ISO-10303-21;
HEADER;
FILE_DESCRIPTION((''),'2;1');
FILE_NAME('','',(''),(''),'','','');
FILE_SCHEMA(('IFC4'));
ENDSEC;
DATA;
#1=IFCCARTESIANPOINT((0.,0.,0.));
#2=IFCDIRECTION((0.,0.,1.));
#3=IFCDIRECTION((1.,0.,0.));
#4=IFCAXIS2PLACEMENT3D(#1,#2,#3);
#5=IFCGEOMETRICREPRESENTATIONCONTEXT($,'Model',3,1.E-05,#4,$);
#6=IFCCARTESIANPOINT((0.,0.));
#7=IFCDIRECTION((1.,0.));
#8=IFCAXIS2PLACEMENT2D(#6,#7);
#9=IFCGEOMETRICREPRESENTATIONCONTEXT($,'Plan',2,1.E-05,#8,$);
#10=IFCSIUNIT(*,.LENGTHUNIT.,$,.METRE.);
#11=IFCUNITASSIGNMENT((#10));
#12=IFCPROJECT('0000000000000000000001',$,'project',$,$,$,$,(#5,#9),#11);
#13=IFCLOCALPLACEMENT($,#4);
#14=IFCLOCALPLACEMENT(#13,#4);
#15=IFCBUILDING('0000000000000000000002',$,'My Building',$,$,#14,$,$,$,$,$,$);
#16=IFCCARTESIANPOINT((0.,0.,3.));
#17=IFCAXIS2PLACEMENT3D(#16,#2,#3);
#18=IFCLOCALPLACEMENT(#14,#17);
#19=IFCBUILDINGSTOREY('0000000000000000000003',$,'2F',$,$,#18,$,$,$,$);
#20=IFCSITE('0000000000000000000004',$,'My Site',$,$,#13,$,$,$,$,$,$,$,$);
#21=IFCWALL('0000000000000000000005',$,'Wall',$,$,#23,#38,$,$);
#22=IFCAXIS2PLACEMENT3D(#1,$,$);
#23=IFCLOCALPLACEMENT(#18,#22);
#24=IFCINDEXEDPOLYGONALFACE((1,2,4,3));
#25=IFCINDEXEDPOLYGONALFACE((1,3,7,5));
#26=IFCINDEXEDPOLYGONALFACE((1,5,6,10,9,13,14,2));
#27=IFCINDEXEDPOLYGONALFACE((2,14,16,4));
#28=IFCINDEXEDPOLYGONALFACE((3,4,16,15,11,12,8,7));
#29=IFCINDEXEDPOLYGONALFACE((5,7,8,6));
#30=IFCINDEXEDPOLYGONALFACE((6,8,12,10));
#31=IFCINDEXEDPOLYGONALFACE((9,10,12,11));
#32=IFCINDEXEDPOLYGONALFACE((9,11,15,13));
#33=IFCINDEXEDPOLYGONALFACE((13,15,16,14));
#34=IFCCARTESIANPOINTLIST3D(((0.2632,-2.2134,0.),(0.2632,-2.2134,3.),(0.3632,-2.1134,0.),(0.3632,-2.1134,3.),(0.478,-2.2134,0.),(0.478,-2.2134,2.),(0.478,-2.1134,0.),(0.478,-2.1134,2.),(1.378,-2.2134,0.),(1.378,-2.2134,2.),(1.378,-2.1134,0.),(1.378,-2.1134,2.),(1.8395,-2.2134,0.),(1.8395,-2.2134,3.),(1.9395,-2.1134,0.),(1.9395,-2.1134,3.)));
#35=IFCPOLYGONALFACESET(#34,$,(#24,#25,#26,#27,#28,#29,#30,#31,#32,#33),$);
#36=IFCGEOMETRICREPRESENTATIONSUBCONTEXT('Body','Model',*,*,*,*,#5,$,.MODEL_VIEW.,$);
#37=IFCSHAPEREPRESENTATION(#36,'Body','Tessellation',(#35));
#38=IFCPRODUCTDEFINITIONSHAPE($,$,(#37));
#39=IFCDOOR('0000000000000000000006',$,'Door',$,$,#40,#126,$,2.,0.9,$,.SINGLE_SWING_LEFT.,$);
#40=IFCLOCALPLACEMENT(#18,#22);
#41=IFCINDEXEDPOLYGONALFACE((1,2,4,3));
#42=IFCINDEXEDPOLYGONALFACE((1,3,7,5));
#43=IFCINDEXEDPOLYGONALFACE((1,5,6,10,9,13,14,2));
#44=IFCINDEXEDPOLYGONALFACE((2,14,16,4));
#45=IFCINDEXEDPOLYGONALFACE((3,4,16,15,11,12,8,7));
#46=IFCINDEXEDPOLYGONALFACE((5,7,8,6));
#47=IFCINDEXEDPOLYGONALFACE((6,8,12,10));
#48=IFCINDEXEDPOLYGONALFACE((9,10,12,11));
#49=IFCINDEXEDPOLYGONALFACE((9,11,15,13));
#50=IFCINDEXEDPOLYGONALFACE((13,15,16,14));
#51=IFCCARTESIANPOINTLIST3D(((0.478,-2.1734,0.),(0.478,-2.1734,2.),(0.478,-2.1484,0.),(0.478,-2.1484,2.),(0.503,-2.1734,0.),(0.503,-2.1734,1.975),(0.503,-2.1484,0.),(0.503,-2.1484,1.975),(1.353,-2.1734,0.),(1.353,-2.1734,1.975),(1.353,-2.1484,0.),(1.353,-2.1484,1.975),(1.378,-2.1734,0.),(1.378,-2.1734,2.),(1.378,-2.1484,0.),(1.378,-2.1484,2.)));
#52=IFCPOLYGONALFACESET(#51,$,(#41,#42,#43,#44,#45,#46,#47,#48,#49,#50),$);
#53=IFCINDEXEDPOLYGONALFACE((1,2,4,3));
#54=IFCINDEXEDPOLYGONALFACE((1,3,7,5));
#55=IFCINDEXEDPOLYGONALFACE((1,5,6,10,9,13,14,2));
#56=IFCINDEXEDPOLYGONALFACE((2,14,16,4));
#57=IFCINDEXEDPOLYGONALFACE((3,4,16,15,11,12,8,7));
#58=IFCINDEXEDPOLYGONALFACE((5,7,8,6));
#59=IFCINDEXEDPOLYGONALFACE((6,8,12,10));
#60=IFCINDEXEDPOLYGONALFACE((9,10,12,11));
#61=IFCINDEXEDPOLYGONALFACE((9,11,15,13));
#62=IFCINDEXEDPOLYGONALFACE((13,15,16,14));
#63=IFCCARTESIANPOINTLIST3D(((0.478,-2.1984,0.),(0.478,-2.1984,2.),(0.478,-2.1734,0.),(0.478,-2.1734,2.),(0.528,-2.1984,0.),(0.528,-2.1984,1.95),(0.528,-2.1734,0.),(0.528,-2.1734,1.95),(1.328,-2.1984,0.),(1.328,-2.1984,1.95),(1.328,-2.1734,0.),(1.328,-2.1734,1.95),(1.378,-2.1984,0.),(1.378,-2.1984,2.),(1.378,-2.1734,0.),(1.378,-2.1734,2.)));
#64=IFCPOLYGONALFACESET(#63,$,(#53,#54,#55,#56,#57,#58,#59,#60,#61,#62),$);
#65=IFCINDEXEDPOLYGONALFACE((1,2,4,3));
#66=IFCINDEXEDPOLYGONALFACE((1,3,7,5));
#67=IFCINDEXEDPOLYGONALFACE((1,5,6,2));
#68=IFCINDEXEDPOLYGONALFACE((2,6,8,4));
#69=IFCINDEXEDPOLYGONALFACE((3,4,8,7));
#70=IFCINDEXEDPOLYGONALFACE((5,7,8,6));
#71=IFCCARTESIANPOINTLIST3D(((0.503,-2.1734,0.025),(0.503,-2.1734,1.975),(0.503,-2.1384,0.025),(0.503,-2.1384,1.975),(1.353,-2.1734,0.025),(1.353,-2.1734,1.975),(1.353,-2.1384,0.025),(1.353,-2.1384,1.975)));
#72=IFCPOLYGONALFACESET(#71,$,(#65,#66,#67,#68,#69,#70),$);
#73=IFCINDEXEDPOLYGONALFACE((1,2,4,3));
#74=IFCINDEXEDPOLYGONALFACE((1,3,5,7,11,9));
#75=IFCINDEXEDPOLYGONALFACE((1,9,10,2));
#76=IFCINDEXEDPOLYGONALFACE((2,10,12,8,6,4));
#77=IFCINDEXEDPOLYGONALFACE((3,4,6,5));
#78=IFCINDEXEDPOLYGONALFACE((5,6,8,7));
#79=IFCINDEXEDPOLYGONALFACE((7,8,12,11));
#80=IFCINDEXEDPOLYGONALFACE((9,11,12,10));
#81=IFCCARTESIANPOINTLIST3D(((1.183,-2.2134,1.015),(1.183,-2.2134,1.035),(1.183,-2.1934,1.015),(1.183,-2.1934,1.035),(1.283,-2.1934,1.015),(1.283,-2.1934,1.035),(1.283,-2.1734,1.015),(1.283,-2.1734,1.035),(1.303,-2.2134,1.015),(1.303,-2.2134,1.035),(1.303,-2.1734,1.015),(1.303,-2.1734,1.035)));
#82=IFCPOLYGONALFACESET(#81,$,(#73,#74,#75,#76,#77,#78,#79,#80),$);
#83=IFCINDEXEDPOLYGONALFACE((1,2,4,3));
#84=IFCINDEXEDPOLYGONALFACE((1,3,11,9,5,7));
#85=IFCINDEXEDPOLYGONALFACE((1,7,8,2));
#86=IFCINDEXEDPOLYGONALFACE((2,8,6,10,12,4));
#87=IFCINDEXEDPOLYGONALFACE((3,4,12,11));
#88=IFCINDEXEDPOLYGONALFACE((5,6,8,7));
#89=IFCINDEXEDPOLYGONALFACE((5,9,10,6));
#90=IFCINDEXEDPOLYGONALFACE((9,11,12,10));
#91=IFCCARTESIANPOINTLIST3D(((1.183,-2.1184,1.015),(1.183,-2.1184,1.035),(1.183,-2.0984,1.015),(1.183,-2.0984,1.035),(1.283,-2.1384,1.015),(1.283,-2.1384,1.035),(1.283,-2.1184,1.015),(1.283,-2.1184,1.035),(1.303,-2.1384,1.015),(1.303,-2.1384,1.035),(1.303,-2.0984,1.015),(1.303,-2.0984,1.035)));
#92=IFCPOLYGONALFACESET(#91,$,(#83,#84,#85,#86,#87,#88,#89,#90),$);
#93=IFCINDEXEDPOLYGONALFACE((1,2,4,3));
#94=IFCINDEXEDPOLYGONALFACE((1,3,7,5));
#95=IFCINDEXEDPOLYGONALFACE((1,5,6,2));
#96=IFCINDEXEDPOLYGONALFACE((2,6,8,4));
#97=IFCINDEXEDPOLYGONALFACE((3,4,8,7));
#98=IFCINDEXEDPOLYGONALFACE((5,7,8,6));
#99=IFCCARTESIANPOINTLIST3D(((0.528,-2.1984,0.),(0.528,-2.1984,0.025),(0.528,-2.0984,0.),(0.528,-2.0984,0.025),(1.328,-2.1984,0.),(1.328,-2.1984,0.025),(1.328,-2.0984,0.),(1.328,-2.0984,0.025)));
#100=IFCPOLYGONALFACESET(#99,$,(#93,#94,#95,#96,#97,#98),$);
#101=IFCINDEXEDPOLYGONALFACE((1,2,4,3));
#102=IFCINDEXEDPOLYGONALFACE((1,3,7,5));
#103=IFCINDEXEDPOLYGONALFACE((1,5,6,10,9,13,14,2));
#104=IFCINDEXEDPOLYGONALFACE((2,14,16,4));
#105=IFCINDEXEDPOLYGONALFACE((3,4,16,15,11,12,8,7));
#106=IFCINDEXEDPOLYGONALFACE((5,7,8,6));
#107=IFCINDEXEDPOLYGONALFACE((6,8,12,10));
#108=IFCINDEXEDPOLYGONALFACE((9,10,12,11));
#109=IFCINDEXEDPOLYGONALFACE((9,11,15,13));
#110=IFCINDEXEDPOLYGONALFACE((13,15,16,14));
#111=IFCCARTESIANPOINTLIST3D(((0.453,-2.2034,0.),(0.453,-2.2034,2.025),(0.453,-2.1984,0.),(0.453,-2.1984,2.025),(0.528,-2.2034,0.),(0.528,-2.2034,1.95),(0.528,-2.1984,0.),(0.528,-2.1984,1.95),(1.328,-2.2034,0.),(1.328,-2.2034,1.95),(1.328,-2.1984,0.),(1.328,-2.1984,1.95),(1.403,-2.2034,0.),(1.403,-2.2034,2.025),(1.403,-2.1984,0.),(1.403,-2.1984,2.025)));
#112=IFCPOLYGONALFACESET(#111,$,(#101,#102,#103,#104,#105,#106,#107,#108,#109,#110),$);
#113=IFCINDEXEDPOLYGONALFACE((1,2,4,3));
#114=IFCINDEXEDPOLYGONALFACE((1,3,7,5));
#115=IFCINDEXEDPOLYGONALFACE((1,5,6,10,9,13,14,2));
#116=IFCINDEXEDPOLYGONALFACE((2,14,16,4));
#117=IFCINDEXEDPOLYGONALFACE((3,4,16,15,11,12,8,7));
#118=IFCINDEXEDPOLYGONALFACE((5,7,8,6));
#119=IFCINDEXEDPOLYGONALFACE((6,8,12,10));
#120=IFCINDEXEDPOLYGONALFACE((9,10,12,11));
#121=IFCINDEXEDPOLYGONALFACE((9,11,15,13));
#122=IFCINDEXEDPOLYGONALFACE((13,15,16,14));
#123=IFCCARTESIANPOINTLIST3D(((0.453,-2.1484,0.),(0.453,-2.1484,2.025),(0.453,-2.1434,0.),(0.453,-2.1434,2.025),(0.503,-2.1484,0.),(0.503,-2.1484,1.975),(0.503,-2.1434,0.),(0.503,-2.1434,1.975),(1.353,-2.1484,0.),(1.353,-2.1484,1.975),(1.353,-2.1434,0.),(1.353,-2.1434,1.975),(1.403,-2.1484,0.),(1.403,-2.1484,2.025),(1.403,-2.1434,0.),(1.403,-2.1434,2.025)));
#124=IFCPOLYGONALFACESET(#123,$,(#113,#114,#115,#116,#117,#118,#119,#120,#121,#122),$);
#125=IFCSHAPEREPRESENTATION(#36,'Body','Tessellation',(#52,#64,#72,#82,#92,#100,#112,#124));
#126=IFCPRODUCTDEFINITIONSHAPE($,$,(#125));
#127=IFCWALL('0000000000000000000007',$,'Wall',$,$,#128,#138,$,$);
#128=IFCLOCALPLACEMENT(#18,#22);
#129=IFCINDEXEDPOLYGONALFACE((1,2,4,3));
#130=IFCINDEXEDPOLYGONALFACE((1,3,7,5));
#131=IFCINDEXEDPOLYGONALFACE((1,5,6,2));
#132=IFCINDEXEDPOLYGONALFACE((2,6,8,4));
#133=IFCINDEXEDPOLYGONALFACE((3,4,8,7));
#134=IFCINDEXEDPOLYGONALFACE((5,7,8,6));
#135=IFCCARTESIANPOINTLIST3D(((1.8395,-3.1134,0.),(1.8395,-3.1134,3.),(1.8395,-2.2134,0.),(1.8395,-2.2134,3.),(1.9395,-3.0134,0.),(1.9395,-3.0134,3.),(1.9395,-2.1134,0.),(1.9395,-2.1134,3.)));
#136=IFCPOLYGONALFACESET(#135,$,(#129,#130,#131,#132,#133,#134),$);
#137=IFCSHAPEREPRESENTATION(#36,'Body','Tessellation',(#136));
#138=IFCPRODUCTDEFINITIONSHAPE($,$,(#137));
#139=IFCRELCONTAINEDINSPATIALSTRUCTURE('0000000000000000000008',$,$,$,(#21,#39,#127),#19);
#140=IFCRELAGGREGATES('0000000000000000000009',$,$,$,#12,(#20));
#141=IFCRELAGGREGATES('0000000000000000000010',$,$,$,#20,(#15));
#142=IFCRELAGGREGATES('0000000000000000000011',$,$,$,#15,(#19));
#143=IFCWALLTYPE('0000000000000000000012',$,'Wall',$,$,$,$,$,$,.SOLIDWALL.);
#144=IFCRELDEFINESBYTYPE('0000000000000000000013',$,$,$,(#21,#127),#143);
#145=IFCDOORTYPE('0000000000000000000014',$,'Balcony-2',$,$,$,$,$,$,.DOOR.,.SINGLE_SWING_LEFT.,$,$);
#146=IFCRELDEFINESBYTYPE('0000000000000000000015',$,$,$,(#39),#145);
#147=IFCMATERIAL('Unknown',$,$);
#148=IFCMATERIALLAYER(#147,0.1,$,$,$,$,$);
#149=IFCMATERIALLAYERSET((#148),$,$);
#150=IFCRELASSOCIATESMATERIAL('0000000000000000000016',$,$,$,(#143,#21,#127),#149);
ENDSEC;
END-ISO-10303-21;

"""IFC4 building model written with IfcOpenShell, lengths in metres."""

from ifc_helpers import new_model, entity, si_unit, frame, origin_with_axes, origin_2d_with_axis, place, context, subcontext, project, spatial, line, indexed_curve, outline, extrude, shape, source, transform, mapped, material, layer, layer_set, layer_usage, type_object, type_shapes, element, fill, save


model = new_model("IFC4")

# Units and contexts
model_context = context("Model", 3, precision=1e-05, world=origin_with_axes())
plan_context = context("Plan", 2, precision=1e-05, world=origin_2d_with_axis())
body_context_1 = subcontext(model_context, "Body", "Model", "MODEL_VIEW")
body_context_2 = subcontext(plan_context, "Body", "Plan", "PLAN_VIEW")
ifc_project = project(units=[si_unit("LENGTHUNIT", "METRE")], contexts=[model_context, plan_context])

# Site, building, storey
site_placement = place(None, origin_with_axes())
site = spatial("IfcSite", under=ifc_project, at=site_placement, Name="My Site")
building_placement = place(site_placement, origin_with_axes())
building = spatial("IfcBuilding", under=site, at=building_placement, Name="My Building")
storey_placement = place(building_placement, frame((0.0, 0.0, 3.0), z_axis=(0.0, 0.0, 1.0), x_axis=(1.0, 0.0, 0.0)))
storey = spatial("IfcBuildingStorey", under=building, at=storey_placement, Name="2F")

# Shared definitions
ifc_material = material(Name="Unknown")

# Shared definitions
ifc_layer_1 = layer(ifc_material, 0.1)
ifc_layer_set_1 = layer_set([ifc_layer_1])
wall_type = type_object("IfcWallType", Name="Wall", PredefinedType="SOLIDWALL", material=ifc_layer_set_1)

# Wall, opening, door
ifc_layer_usage_1 = layer_usage(ifc_layer_set_1, "AXIS2", "POSITIVE", 0.0)
wall_1_placement = place(storey_placement, frame((0.2632, -2.2134, 0.0), z_axis=(0.0, 0.0, 1.0), x_axis=(1.0, 0.0, 0.0)))
wall_1 = element("IfcWall", 1, at=wall_1_placement, inside=storey, type_object=wall_type, material=ifc_layer_usage_1, Name="Wall", context=body_context_1, shape_type="SweptSolid", body=[
    extrude(outline(indexed_curve([(0.0, 0.0), (0.1, 0.1), (1.6764, 0.1), (1.5764, 0.0)], segments=[line(1, 2, 3, 4, 1)])), origin_with_axes(), (0.0, 0.0, 1.0), 3.0),
])
shared_shape_1 = source(origin_with_axes(), body_context_1, "Body", "SweptSolid", [
    extrude(outline(indexed_curve([(0.0, 0.0), (0.9, 0.0), (0.9, 2.0), (0.0, 2.0)], segments=[line(1, 2, 3, 4, 1)])), frame((0.0, -0.6, 0.0), z_axis=(0.0, -1.0, 0.0), x_axis=(1.0, 0.0, 0.0)), (0.0, 0.0, -1.0), 1.2),
])
opening_1_placement = place(wall_1_placement, frame((0.2148, 0.015, 0.0), z_axis=(0.0, 0.0, 1.0), x_axis=(1.0, 0.0, 0.0)))
opening_1 = element("IfcOpeningElement", 2, at=opening_1_placement, cuts=wall_1, PredefinedType="OPENING", context=body_context_1, shape_type="MappedRepresentation", body=[
    mapped(shared_shape_1, transform((0.0, 0.0, 0.0), x_axis=(1.0, 0.0, 0.0), y_axis=(0.0, 1.0, 0.0), z_axis=(0.0, 0.0, 1.0), scale=1.0)),
])
door_type_1 = type_object("IfcDoorType", Name="Balcony-2", OperationType="SINGLE_SWING_LEFT", PredefinedType="DOOR")
shared_shape_2 = source(origin_with_axes(), body_context_1, "Body", "SweptSolid", [
    extrude(outline(indexed_curve([(0.0, 0.0), (0.0, 2.0), (0.9, 2.0), (0.9, 0.0), (0.875, 0.0), (0.875, 1.975), (0.025, 1.975), (0.025, 0.0)], segments=[line(1, 2, 3, 4, 5, 6, 7, 8, 1)])), frame((0.0, 0.025, 0.0), z_axis=(0.0, -1.0, 0.0), x_axis=(1.0, 0.0, 0.0)), (0.0, 0.0, -1.0), 0.025),
    extrude(outline(indexed_curve([(0.0, 0.0), (0.0, 2.0), (0.9, 2.0), (0.9, 0.0), (0.85, 0.0), (0.85, 1.95), (0.05, 1.95), (0.05, 0.0)], segments=[line(1, 2, 3, 4, 5, 6, 7, 8, 1)])), frame((0.0, 0.0, 0.0), z_axis=(0.0, -1.0, 0.0), x_axis=(1.0, 0.0, 0.0)), (0.0, 0.0, -1.0), 0.025),
    extrude(outline(indexed_curve([(0.0, 0.0), (0.85, 0.0), (0.85, 0.035), (0.0, 0.035)], segments=[line(1, 2, 3, 4, 1)])), frame((0.025, 0.025, 0.025), z_axis=(0.0, 0.0, 1.0), x_axis=(1.0, 0.0, 0.0)), (0.0, 0.0, 1.0), 1.95),
    extrude(outline(indexed_curve([(0.0, 0.0), (0.0, -0.04), (-0.12, -0.04), (-0.12, -0.02), (-0.02, -0.02), (-0.02, 0.0)], segments=[line(1, 2, 3, 4, 5, 6, 1)])), frame((0.825, 0.025, 1.015), z_axis=(0.0, 0.0, 1.0), x_axis=(1.0, 0.0, 0.0)), (0.0, 0.0, 1.0), 0.02),
    extrude(outline(indexed_curve([(0.0, 0.0), (0.0, 0.04), (-0.12, 0.04), (-0.12, 0.02), (-0.02, 0.02), (-0.02, 0.0)], segments=[line(1, 2, 3, 4, 5, 6, 1)])), frame((0.825, 0.06, 1.015), z_axis=(0.0, 0.0, 1.0), x_axis=(1.0, 0.0, 0.0)), (0.0, 0.0, 1.0), 0.02),
    extrude(outline(indexed_curve([(0.0, 0.0), (0.8, 0.0), (0.8, 0.1), (0.0, 0.1)], segments=[line(1, 2, 3, 4, 1)])), frame((0.05, 0.0, 0.0), z_axis=(0.0, 0.0, 1.0), x_axis=(1.0, 0.0, 0.0)), (0.0, 0.0, 1.0), 0.025),
    extrude(outline(indexed_curve([(0.0, 0.0), (0.0, 2.025), (0.95, 2.025), (0.95, 0.0), (0.875, 0.0), (0.875, 1.95), (0.075, 1.95), (0.075, 0.0)], segments=[line(1, 2, 3, 4, 5, 6, 7, 8, 1)])), frame((-0.025, -0.005, 0.0), z_axis=(0.0, -1.0, 0.0), x_axis=(1.0, 0.0, 0.0)), (0.0, 0.0, -1.0), 0.005),
    extrude(outline(indexed_curve([(0.0, 0.0), (0.0, 2.025), (0.95, 2.025), (0.95, 0.0), (0.9, 0.0), (0.9, 1.975), (0.05, 1.975), (0.05, 0.0)], segments=[line(1, 2, 3, 4, 5, 6, 7, 8, 1)])), frame((-0.025, 0.05, 0.0), z_axis=(0.0, -1.0, 0.0), x_axis=(1.0, 0.0, 0.0)), (0.0, 0.0, -1.0), 0.005),
])
shared_shape_3 = source(origin_with_axes(), body_context_2, "Body", "Curve2D", [
    entity("IfcIndexedPolyCurve", entity("IfcCartesianPointList2D", [[0.0, 0.0], [0.0, 0.05], [0.025, 0.05], [0.025, 0.025], [0.05, 0.025], [0.05, 0.0]]), [entity("IfcLineIndex", [1, 2, 3, 4, 5, 6, 1])]),
    entity("IfcIndexedPolyCurve", entity("IfcCartesianPointList2D", [[0.9, 0.0], [0.9, 0.05], [0.875, 0.05], [0.875, 0.025], [0.85, 0.025], [0.85, 0.0]]), [entity("IfcLineIndex", [1, 2, 3, 4, 5, 6, 1])]),
    entity("IfcTrimmedCurve", entity("IfcEllipse", entity("IfcAxis2Placement2D", entity("IfcCartesianPoint", [0.06, 0.05]), entity("IfcDirection", [1.0, 0.0])), 0.815, 0.85), [entity("IfcCartesianPoint", [0.875, 0.05])], [entity("IfcCartesianPoint", [0.06, 0.9])], True, "CARTESIAN"),
    entity("IfcIndexedPolyCurve", entity("IfcCartesianPointList2D", [[0.025, 0.05], [0.06, 0.05], [0.06, 0.9], [0.025, 0.9]]), [entity("IfcLineIndex", [1, 2, 3, 4, 1])]),
])
type_shapes(door_type_1, [shared_shape_2, shared_shape_3])
door_1_placement = place(opening_1_placement, frame((0.0, 0.0, 0.0), z_axis=(0.0, 0.0, 1.0), x_axis=(1.0, 0.0, 0.0)))
door_1 = element("IfcDoor", 3, at=door_1_placement, inside=storey, type_object=door_type_1, Name="Door", OperationType="SINGLE_SWING_LEFT", OverallHeight=2.0, OverallWidth=0.9, shapes=[
    shape(body_context_1, "Body", "MappedRepresentation", [mapped(shared_shape_2, transform((0.0, 0.0, 0.0), x_axis=(1.0, 0.0, 0.0), y_axis=(0.0, 1.0, 0.0), z_axis=(0.0, 0.0, 1.0), scale=1.0))]),
    shape(body_context_2, "Body", "MappedRepresentation", [mapped(shared_shape_3, transform((0.0, 0.0, 0.0), x_axis=(1.0, 0.0, 0.0), y_axis=(0.0, 1.0, 0.0), z_axis=(0.0, 0.0, 1.0), scale=1.0))]),
])
fill(opening_1, door_1)

# Wall
ifc_layer_usage_2 = layer_usage(ifc_layer_set_1, "AXIS2", "POSITIVE", 0.0)
wall_2_placement = place(storey_placement, frame((1.8395, -2.2134, 0.0), z_axis=(0.0, 0.0, 1.0), x_axis=(0.0, -1.0, 0.0)))
element("IfcWall", 4, at=wall_2_placement, inside=storey, type_object=wall_type, material=ifc_layer_usage_2, Name="Wall", context=body_context_1, shape_type="SweptSolid", body=[
    extrude(outline(indexed_curve([(0.0, 0.0), (-0.1, 0.1), (0.8, 0.1), (0.9, 0.0)], segments=[line(1, 2, 3, 4, 1)])), origin_with_axes(), (0.0, 0.0, 1.0), 3.0),
])

save(model, "model.ifc")
